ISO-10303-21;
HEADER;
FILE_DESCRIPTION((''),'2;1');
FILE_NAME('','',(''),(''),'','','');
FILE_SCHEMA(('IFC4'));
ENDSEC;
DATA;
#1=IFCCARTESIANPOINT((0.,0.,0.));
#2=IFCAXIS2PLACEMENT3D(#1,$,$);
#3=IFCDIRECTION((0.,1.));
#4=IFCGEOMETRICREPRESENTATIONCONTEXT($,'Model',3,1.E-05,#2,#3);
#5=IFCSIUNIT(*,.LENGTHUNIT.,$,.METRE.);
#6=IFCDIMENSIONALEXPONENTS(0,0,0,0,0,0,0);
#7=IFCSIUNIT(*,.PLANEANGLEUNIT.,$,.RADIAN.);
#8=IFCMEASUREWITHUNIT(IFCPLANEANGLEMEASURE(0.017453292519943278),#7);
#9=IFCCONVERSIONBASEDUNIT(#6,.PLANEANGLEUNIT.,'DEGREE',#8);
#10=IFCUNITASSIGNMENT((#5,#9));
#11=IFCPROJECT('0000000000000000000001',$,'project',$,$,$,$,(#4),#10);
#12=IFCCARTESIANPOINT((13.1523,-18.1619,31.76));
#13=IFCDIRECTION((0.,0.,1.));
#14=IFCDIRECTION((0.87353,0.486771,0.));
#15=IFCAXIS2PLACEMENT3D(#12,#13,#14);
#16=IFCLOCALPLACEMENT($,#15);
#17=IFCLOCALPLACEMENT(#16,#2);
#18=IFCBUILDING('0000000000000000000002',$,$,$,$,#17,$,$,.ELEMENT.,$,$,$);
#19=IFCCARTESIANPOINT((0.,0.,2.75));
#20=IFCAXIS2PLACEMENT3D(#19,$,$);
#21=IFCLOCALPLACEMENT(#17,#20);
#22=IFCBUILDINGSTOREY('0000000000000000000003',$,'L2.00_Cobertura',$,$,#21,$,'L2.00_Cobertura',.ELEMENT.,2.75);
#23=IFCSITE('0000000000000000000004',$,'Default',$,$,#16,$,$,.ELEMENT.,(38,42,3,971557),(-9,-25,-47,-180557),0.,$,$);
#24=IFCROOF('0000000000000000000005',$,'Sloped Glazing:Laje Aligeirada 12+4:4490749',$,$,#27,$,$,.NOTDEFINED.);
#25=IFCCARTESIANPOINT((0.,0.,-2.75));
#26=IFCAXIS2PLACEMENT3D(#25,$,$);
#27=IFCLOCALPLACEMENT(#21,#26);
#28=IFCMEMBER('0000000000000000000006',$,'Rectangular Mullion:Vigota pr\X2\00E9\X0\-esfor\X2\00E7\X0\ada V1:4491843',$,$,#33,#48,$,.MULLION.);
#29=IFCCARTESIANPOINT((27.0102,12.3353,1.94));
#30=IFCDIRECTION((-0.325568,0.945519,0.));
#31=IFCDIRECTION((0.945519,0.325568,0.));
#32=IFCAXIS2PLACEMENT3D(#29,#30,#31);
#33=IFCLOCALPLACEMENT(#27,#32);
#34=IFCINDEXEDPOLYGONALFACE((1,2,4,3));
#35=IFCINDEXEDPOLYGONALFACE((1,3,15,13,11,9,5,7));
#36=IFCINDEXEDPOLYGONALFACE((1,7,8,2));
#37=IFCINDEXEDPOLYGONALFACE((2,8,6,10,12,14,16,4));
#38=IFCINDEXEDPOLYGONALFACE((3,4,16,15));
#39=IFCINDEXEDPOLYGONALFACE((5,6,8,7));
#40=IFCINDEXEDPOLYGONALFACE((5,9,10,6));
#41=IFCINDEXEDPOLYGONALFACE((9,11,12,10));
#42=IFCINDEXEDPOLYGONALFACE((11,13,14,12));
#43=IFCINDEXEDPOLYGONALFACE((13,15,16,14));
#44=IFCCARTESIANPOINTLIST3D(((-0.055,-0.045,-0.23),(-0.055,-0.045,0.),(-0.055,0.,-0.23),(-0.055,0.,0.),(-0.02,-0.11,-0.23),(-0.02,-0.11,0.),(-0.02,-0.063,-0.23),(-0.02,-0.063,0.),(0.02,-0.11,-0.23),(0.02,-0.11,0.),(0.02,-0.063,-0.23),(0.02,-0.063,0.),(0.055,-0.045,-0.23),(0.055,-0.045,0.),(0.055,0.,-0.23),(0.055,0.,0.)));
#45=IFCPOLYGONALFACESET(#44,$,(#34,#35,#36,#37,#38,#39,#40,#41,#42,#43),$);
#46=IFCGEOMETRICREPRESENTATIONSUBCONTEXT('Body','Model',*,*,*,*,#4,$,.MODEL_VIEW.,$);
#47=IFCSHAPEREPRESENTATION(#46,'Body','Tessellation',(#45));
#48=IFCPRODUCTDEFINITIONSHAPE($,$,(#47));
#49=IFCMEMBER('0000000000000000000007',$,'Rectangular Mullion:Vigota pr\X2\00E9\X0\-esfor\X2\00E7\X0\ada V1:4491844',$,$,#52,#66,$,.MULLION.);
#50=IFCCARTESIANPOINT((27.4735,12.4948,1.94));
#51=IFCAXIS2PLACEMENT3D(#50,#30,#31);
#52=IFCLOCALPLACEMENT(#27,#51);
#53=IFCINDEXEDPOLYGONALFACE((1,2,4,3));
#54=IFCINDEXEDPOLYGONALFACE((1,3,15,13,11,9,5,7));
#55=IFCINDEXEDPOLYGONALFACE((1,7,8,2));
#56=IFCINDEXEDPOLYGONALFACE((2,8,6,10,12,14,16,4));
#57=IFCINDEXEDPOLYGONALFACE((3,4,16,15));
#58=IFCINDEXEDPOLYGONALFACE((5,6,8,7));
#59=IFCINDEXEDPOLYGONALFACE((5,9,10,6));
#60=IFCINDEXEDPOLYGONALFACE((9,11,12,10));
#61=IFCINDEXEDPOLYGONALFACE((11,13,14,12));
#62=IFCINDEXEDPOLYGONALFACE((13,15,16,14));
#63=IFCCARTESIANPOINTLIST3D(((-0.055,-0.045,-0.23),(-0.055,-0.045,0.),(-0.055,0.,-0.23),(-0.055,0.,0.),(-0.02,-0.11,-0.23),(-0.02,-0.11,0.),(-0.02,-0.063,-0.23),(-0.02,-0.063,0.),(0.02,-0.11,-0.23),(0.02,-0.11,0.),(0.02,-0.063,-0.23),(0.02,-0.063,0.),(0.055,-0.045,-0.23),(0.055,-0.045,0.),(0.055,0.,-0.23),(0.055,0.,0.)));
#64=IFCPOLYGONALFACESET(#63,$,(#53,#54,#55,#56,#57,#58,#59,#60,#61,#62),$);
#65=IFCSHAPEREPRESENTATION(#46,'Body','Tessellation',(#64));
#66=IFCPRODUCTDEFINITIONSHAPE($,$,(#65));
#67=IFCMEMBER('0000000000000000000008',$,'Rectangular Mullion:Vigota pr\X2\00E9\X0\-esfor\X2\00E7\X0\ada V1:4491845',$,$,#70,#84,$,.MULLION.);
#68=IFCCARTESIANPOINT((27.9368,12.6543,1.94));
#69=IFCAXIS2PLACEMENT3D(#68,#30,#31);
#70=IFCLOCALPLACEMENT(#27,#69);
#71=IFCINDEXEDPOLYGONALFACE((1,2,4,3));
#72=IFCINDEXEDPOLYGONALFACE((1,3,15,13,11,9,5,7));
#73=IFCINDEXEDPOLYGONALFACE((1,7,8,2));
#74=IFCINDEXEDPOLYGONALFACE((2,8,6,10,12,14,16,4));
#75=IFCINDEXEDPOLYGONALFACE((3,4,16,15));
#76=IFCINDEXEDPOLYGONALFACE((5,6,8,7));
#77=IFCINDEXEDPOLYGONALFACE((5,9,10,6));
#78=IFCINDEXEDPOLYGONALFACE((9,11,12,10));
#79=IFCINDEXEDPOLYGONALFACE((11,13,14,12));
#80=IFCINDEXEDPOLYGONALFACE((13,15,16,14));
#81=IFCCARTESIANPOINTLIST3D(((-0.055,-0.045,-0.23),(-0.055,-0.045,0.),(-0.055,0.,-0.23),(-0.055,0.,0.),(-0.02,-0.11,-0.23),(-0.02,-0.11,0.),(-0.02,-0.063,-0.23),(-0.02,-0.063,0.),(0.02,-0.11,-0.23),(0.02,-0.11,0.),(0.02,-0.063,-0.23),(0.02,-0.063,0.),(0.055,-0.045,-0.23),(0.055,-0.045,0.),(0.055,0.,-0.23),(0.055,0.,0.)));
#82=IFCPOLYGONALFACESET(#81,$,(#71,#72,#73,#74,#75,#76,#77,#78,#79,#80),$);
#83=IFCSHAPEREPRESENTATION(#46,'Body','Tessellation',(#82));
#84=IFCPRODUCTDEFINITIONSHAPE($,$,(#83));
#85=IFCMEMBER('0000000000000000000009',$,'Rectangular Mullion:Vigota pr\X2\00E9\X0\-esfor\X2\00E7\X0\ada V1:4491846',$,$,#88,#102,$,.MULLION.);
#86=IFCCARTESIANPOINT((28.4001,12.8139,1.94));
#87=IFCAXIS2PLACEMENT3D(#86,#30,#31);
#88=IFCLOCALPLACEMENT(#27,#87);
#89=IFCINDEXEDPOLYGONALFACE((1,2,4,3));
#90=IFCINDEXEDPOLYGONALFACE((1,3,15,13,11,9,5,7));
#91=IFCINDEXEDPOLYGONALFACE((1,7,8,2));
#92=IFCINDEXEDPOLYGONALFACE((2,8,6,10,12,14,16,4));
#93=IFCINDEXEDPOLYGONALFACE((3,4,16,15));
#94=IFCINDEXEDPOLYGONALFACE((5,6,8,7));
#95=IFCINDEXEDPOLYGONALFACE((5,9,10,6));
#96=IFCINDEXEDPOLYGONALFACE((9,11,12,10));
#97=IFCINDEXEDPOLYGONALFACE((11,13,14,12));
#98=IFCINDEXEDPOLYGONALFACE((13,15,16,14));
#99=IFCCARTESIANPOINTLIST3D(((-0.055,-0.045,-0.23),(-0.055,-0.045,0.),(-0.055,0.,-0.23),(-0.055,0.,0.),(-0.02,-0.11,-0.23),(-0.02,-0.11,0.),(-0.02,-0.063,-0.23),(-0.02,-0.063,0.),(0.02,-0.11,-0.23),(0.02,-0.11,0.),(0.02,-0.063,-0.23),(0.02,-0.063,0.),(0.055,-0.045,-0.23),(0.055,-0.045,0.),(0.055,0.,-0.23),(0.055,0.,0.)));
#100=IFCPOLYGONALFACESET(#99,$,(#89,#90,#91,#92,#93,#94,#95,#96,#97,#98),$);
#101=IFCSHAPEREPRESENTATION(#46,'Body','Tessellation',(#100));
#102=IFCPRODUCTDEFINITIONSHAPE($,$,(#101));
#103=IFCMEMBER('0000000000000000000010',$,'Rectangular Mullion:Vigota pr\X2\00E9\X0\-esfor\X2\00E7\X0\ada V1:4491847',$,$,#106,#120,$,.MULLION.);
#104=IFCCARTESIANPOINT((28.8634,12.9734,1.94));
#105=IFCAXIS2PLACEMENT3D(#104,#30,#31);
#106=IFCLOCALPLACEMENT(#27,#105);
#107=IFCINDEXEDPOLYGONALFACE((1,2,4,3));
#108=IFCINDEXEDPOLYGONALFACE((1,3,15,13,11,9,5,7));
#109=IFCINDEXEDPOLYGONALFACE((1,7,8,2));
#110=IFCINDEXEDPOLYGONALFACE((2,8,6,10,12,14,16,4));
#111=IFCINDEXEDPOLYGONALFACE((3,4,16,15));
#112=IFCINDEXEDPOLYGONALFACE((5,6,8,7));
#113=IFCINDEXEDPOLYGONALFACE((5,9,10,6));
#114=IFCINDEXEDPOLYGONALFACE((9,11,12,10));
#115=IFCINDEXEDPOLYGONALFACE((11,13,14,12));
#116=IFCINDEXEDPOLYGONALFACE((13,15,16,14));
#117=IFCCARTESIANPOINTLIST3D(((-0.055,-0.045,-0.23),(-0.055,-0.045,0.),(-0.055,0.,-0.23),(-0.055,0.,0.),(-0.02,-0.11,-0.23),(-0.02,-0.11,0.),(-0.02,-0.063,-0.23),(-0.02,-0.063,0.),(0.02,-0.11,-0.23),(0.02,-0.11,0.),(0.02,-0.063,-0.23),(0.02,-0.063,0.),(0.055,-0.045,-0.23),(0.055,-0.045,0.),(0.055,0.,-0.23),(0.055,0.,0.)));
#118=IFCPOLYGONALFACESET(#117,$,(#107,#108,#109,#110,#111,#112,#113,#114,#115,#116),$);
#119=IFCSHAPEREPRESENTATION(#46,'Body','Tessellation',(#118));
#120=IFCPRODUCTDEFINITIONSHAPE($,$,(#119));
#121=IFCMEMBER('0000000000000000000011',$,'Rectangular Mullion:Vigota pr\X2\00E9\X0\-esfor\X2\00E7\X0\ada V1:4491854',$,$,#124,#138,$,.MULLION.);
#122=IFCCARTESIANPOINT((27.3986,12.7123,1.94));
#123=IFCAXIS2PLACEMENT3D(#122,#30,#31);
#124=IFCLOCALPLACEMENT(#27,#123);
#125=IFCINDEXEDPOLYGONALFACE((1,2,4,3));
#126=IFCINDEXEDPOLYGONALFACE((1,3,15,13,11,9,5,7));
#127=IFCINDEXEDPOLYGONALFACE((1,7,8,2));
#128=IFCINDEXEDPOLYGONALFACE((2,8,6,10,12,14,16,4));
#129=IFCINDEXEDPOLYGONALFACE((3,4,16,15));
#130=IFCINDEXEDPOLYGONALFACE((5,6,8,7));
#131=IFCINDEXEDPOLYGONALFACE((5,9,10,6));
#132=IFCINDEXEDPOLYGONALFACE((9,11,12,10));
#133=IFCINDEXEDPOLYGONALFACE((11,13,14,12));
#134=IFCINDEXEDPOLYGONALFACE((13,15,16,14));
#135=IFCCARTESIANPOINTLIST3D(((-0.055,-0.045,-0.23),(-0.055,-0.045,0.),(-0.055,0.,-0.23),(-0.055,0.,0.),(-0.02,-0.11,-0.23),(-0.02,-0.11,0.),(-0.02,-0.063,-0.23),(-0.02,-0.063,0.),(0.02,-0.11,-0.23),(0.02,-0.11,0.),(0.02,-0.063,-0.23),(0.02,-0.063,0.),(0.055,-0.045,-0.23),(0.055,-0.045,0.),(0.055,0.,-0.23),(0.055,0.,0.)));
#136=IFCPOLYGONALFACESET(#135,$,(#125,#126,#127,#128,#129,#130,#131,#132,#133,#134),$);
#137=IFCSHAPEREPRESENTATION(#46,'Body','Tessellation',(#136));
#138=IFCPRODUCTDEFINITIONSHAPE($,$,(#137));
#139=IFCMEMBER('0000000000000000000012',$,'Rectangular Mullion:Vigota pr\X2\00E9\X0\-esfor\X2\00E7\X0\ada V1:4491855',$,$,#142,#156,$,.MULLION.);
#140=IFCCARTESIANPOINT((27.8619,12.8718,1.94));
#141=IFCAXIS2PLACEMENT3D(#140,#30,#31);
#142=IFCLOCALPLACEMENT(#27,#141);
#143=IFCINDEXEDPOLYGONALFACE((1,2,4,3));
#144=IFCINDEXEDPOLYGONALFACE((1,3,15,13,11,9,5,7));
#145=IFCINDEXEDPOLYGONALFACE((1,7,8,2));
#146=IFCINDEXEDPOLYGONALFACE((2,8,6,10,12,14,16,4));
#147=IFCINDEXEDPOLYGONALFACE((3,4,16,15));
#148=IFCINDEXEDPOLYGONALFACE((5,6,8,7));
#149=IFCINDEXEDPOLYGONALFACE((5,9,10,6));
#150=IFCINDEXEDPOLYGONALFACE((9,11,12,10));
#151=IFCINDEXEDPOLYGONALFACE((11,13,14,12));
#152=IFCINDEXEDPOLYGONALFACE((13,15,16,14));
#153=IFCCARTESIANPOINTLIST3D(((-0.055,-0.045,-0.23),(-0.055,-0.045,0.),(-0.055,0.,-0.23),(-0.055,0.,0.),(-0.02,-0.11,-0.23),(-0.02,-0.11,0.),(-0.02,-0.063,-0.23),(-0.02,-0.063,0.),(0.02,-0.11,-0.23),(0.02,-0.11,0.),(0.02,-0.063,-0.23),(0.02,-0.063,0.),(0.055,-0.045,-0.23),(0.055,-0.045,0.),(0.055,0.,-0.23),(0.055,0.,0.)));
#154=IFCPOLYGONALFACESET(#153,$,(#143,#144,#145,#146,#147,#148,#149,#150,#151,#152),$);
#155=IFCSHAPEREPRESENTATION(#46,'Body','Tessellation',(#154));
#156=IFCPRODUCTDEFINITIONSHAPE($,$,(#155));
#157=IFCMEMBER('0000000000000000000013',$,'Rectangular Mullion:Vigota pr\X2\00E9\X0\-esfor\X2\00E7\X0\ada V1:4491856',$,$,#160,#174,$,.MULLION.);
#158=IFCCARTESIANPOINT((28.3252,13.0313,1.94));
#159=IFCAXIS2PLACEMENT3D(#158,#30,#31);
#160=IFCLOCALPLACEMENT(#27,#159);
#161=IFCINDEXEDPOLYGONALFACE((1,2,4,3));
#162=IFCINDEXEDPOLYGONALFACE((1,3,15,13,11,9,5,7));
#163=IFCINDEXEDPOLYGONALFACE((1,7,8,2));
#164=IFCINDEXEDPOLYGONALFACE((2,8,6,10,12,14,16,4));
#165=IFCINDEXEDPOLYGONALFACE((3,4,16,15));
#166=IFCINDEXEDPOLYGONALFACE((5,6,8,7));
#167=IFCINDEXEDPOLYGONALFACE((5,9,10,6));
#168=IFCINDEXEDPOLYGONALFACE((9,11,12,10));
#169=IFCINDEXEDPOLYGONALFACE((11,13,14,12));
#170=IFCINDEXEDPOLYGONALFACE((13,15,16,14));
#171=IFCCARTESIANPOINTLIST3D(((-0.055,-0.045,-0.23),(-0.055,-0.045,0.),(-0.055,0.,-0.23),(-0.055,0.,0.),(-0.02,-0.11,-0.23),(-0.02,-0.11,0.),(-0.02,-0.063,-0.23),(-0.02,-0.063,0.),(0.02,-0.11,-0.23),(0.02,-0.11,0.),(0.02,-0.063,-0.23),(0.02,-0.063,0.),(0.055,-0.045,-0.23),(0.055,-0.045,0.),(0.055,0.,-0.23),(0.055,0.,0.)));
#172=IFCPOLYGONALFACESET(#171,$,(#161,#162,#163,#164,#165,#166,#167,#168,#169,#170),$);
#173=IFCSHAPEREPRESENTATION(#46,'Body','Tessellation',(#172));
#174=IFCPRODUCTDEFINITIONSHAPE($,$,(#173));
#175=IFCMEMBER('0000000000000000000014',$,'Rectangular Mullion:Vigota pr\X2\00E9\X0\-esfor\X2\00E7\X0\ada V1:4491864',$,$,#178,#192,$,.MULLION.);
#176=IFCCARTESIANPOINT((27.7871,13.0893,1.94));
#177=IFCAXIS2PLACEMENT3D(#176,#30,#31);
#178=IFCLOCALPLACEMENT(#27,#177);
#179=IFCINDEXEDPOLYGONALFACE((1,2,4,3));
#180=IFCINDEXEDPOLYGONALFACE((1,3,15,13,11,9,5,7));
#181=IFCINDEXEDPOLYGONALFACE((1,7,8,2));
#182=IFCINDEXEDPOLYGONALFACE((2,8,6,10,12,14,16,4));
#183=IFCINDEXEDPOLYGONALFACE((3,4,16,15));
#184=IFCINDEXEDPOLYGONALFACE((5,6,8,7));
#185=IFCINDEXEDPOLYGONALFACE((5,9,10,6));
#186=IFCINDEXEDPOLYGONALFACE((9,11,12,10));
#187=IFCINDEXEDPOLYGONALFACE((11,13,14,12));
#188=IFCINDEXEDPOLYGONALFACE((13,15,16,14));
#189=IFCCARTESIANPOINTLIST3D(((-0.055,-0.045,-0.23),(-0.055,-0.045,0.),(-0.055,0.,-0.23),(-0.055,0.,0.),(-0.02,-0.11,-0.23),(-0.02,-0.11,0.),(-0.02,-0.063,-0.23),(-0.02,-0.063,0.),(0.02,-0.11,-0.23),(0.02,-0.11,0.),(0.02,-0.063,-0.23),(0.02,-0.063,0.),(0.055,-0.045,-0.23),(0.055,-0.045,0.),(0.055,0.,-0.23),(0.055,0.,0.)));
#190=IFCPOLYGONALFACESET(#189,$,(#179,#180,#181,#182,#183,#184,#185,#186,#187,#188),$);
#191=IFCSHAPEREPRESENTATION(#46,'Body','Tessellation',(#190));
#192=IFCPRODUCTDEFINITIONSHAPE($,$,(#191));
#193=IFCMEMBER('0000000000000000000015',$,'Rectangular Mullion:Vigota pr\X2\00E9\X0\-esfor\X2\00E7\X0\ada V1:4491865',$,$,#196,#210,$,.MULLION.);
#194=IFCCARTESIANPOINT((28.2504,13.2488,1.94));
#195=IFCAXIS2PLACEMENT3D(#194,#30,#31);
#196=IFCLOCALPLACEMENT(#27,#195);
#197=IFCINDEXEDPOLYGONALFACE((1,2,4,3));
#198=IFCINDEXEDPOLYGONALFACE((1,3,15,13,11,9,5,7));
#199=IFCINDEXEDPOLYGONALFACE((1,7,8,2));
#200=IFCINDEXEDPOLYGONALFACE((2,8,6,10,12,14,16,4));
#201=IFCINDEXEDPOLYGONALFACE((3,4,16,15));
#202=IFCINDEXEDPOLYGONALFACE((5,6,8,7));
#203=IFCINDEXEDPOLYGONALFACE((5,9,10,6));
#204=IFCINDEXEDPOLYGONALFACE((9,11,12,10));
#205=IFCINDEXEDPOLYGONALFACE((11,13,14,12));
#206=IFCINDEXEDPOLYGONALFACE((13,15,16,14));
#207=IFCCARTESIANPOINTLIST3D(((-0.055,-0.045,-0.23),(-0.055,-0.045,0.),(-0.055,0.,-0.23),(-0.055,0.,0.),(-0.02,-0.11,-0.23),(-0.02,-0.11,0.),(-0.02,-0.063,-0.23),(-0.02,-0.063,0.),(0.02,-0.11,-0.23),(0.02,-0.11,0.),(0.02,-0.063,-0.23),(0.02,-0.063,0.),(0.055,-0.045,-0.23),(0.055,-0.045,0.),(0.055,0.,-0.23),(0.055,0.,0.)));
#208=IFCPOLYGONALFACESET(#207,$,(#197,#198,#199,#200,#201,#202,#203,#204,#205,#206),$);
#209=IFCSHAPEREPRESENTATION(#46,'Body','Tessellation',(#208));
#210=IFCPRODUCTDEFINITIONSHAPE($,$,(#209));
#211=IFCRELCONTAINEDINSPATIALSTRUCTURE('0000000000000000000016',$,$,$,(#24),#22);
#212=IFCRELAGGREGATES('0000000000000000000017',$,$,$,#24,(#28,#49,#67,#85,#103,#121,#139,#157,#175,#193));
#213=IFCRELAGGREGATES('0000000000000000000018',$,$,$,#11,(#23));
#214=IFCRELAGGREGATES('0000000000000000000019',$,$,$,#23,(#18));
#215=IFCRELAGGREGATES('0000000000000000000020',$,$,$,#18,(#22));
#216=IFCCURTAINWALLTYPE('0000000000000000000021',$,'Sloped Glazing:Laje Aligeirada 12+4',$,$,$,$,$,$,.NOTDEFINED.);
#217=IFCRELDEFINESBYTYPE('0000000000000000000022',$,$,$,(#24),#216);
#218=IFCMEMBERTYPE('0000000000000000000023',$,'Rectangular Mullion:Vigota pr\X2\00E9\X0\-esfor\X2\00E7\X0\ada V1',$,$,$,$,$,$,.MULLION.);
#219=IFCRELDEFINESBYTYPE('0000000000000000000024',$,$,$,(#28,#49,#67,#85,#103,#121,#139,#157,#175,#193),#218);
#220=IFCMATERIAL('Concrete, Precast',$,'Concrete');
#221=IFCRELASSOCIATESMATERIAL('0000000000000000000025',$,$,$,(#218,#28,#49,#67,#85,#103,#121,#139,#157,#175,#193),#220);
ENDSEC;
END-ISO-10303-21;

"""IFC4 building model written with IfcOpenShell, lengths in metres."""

from ifc_helpers import new_model, entity, si_unit, converted_unit, direction, frame, origin, place, context, subcontext, project, spatial, indexed_curve, outline, extrude, source, transform, mapped, material, type_object, type_shapes, element, aggregate, save


model = new_model("IFC4")

# Units and contexts
model_context = context("Model", 3, precision=1e-05, world=origin(), true_north=direction((0.0, 1.0)))
body_context = subcontext(model_context, "Body", "Model", "MODEL_VIEW")
ifc_project = project(units=[si_unit("LENGTHUNIT", "METRE"), converted_unit("PLANEANGLEUNIT", "DEGREE", entity("IfcPlaneAngleMeasure", 0.017453292519943278), si_unit("PLANEANGLEUNIT", "RADIAN"), dimensions=[0, 0, 0, 0, 0, 0, 0])], contexts=[model_context])

# Site, building, storey
site_placement = place(None, frame((13.1523, -18.1619, 31.76), z_axis=(0.0, 0.0, 1.0), x_axis=(0.87353, 0.486771, 0.0)))
site = spatial("IfcSite", under=ifc_project, at=site_placement, Name="Default", CompositionType="ELEMENT", RefLatitude=(38, 42, 3, 971557), RefLongitude=(-9, -25, -47, -180557), RefElevation=0.0)
building_placement = place(site_placement, origin())
building = spatial("IfcBuilding", under=site, at=building_placement, CompositionType="ELEMENT")
storey_placement = place(building_placement, frame((0.0, 0.0, 2.75)))
storey = spatial("IfcBuildingStorey", under=building, at=storey_placement, Name="L2.00_Cobertura", LongName="L2.00_Cobertura", CompositionType="ELEMENT", Elevation=2.75)

# Roof, members
curtain_wall_type = type_object("IfcCurtainWallType", Name="Sloped Glazing:Laje Aligeirada 12+4", PredefinedType="NOTDEFINED")
roof_placement = place(storey_placement, frame((0.0, 0.0, -2.75)))
roof = element("IfcRoof", 1, at=roof_placement, inside=storey, type_object=curtain_wall_type, Name="Sloped Glazing:Laje Aligeirada 12+4:4490749", PredefinedType="NOTDEFINED")
ifc_material_1 = material(Name="Concrete, Precast", Category="Concrete")
member_type_1 = type_object("IfcMemberType", Name="Rectangular Mullion:Vigota pré-esforçada V1", PredefinedType="MULLION", material=ifc_material_1)
shared_shape_1 = source(origin(), body_context, "Body", "SweptSolid", [
    extrude(outline(indexed_curve([(-0.055, -0.0545), (0.055, -0.0545), (0.055, -0.0095), (0.02, 0.0085), (0.02, 0.0555), (-0.02, 0.0555), (-0.02, 0.0085), (-0.055, -0.0095), (-0.055, -0.0545)], self_intersect=False)), frame((0.0, -0.0545, -0.23), z_axis=(0.0, 0.0, 1.0), x_axis=(-1.0, 0.0, 0.0)), (0.0, 0.0, 1.0), 0.23),
])
type_shapes(member_type_1, [shared_shape_1])
member_1_placement = place(roof_placement, frame((27.0102, 12.3353, 1.94), z_axis=(-0.325568, 0.945519, 0.0), x_axis=(0.945519, 0.325568, 0.0)))
member_1 = element("IfcMember", 2, at=member_1_placement, type_object=member_type_1, material=ifc_material_1, Name="Rectangular Mullion:Vigota pré-esforçada V1:4491843", PredefinedType="MULLION", context=body_context, shape_type="MappedRepresentation", body=[
    mapped(shared_shape_1, transform((0.0, 0.0, 0.0), scale=1.0)),
])
member_2_placement = place(roof_placement, frame((27.4735, 12.4948, 1.94), z_axis=(-0.325568, 0.945519, 0.0), x_axis=(0.945519, 0.325568, 0.0)))
member_2 = element("IfcMember", 3, at=member_2_placement, type_object=member_type_1, material=ifc_material_1, Name="Rectangular Mullion:Vigota pré-esforçada V1:4491844", PredefinedType="MULLION", context=body_context, shape_type="MappedRepresentation", body=[
    mapped(shared_shape_1, transform((0.0, 0.0, 0.0), scale=1.0)),
])
member_3_placement = place(roof_placement, frame((27.9368, 12.6543, 1.94), z_axis=(-0.325568, 0.945519, 0.0), x_axis=(0.945519, 0.325568, 0.0)))
member_3 = element("IfcMember", 4, at=member_3_placement, type_object=member_type_1, material=ifc_material_1, Name="Rectangular Mullion:Vigota pré-esforçada V1:4491845", PredefinedType="MULLION", context=body_context, shape_type="MappedRepresentation", body=[
    mapped(shared_shape_1, transform((0.0, 0.0, 0.0), scale=1.0)),
])
member_4_placement = place(roof_placement, frame((28.4001, 12.8139, 1.94), z_axis=(-0.325568, 0.945519, 0.0), x_axis=(0.945519, 0.325568, 0.0)))
member_4 = element("IfcMember", 5, at=member_4_placement, type_object=member_type_1, material=ifc_material_1, Name="Rectangular Mullion:Vigota pré-esforçada V1:4491846", PredefinedType="MULLION", context=body_context, shape_type="MappedRepresentation", body=[
    mapped(shared_shape_1, transform((0.0, 0.0, 0.0), scale=1.0)),
])
member_5_placement = place(roof_placement, frame((28.8634, 12.9734, 1.94), z_axis=(-0.325568, 0.945519, 0.0), x_axis=(0.945519, 0.325568, 0.0)))
member_5 = element("IfcMember", 6, at=member_5_placement, type_object=member_type_1, material=ifc_material_1, Name="Rectangular Mullion:Vigota pré-esforçada V1:4491847", PredefinedType="MULLION", context=body_context, shape_type="MappedRepresentation", body=[
    mapped(shared_shape_1, transform((0.0, 0.0, 0.0), scale=1.0)),
])
member_6_placement = place(roof_placement, frame((27.3986, 12.7123, 1.94), z_axis=(-0.325568, 0.945519, 0.0), x_axis=(0.945519, 0.325568, 0.0)))
member_6 = element("IfcMember", 7, at=member_6_placement, type_object=member_type_1, material=ifc_material_1, Name="Rectangular Mullion:Vigota pré-esforçada V1:4491854", PredefinedType="MULLION", context=body_context, shape_type="MappedRepresentation", body=[
    mapped(shared_shape_1, transform((0.0, 0.0, 0.0), scale=1.0)),
])
member_7_placement = place(roof_placement, frame((27.8619, 12.8718, 1.94), z_axis=(-0.325568, 0.945519, 0.0), x_axis=(0.945519, 0.325568, 0.0)))
member_7 = element("IfcMember", 8, at=member_7_placement, type_object=member_type_1, material=ifc_material_1, Name="Rectangular Mullion:Vigota pré-esforçada V1:4491855", PredefinedType="MULLION", context=body_context, shape_type="MappedRepresentation", body=[
    mapped(shared_shape_1, transform((0.0, 0.0, 0.0), scale=1.0)),
])
member_8_placement = place(roof_placement, frame((28.3252, 13.0313, 1.94), z_axis=(-0.325568, 0.945519, 0.0), x_axis=(0.945519, 0.325568, 0.0)))
member_8 = element("IfcMember", 9, at=member_8_placement, type_object=member_type_1, material=ifc_material_1, Name="Rectangular Mullion:Vigota pré-esforçada V1:4491856", PredefinedType="MULLION", context=body_context, shape_type="MappedRepresentation", body=[
    mapped(shared_shape_1, transform((0.0, 0.0, 0.0), scale=1.0)),
])
member_9_placement = place(roof_placement, frame((27.7871, 13.0893, 1.94), z_axis=(-0.325568, 0.945519, 0.0), x_axis=(0.945519, 0.325568, 0.0)))
member_9 = element("IfcMember", 10, at=member_9_placement, type_object=member_type_1, material=ifc_material_1, Name="Rectangular Mullion:Vigota pré-esforçada V1:4491864", PredefinedType="MULLION", context=body_context, shape_type="MappedRepresentation", body=[
    mapped(shared_shape_1, transform((0.0, 0.0, 0.0), scale=1.0)),
])
member_10_placement = place(roof_placement, frame((28.2504, 13.2488, 1.94), z_axis=(-0.325568, 0.945519, 0.0), x_axis=(0.945519, 0.325568, 0.0)))
member_10 = element("IfcMember", 11, at=member_10_placement, type_object=member_type_1, material=ifc_material_1, Name="Rectangular Mullion:Vigota pré-esforçada V1:4491865", PredefinedType="MULLION", context=body_context, shape_type="MappedRepresentation", body=[
    mapped(shared_shape_1, transform((0.0, 0.0, 0.0), scale=1.0)),
])
aggregate(roof, [member_1, member_2, member_3, member_4, member_5, member_6, member_7, member_8, member_9, member_10])

save(model, "model.ifc")
